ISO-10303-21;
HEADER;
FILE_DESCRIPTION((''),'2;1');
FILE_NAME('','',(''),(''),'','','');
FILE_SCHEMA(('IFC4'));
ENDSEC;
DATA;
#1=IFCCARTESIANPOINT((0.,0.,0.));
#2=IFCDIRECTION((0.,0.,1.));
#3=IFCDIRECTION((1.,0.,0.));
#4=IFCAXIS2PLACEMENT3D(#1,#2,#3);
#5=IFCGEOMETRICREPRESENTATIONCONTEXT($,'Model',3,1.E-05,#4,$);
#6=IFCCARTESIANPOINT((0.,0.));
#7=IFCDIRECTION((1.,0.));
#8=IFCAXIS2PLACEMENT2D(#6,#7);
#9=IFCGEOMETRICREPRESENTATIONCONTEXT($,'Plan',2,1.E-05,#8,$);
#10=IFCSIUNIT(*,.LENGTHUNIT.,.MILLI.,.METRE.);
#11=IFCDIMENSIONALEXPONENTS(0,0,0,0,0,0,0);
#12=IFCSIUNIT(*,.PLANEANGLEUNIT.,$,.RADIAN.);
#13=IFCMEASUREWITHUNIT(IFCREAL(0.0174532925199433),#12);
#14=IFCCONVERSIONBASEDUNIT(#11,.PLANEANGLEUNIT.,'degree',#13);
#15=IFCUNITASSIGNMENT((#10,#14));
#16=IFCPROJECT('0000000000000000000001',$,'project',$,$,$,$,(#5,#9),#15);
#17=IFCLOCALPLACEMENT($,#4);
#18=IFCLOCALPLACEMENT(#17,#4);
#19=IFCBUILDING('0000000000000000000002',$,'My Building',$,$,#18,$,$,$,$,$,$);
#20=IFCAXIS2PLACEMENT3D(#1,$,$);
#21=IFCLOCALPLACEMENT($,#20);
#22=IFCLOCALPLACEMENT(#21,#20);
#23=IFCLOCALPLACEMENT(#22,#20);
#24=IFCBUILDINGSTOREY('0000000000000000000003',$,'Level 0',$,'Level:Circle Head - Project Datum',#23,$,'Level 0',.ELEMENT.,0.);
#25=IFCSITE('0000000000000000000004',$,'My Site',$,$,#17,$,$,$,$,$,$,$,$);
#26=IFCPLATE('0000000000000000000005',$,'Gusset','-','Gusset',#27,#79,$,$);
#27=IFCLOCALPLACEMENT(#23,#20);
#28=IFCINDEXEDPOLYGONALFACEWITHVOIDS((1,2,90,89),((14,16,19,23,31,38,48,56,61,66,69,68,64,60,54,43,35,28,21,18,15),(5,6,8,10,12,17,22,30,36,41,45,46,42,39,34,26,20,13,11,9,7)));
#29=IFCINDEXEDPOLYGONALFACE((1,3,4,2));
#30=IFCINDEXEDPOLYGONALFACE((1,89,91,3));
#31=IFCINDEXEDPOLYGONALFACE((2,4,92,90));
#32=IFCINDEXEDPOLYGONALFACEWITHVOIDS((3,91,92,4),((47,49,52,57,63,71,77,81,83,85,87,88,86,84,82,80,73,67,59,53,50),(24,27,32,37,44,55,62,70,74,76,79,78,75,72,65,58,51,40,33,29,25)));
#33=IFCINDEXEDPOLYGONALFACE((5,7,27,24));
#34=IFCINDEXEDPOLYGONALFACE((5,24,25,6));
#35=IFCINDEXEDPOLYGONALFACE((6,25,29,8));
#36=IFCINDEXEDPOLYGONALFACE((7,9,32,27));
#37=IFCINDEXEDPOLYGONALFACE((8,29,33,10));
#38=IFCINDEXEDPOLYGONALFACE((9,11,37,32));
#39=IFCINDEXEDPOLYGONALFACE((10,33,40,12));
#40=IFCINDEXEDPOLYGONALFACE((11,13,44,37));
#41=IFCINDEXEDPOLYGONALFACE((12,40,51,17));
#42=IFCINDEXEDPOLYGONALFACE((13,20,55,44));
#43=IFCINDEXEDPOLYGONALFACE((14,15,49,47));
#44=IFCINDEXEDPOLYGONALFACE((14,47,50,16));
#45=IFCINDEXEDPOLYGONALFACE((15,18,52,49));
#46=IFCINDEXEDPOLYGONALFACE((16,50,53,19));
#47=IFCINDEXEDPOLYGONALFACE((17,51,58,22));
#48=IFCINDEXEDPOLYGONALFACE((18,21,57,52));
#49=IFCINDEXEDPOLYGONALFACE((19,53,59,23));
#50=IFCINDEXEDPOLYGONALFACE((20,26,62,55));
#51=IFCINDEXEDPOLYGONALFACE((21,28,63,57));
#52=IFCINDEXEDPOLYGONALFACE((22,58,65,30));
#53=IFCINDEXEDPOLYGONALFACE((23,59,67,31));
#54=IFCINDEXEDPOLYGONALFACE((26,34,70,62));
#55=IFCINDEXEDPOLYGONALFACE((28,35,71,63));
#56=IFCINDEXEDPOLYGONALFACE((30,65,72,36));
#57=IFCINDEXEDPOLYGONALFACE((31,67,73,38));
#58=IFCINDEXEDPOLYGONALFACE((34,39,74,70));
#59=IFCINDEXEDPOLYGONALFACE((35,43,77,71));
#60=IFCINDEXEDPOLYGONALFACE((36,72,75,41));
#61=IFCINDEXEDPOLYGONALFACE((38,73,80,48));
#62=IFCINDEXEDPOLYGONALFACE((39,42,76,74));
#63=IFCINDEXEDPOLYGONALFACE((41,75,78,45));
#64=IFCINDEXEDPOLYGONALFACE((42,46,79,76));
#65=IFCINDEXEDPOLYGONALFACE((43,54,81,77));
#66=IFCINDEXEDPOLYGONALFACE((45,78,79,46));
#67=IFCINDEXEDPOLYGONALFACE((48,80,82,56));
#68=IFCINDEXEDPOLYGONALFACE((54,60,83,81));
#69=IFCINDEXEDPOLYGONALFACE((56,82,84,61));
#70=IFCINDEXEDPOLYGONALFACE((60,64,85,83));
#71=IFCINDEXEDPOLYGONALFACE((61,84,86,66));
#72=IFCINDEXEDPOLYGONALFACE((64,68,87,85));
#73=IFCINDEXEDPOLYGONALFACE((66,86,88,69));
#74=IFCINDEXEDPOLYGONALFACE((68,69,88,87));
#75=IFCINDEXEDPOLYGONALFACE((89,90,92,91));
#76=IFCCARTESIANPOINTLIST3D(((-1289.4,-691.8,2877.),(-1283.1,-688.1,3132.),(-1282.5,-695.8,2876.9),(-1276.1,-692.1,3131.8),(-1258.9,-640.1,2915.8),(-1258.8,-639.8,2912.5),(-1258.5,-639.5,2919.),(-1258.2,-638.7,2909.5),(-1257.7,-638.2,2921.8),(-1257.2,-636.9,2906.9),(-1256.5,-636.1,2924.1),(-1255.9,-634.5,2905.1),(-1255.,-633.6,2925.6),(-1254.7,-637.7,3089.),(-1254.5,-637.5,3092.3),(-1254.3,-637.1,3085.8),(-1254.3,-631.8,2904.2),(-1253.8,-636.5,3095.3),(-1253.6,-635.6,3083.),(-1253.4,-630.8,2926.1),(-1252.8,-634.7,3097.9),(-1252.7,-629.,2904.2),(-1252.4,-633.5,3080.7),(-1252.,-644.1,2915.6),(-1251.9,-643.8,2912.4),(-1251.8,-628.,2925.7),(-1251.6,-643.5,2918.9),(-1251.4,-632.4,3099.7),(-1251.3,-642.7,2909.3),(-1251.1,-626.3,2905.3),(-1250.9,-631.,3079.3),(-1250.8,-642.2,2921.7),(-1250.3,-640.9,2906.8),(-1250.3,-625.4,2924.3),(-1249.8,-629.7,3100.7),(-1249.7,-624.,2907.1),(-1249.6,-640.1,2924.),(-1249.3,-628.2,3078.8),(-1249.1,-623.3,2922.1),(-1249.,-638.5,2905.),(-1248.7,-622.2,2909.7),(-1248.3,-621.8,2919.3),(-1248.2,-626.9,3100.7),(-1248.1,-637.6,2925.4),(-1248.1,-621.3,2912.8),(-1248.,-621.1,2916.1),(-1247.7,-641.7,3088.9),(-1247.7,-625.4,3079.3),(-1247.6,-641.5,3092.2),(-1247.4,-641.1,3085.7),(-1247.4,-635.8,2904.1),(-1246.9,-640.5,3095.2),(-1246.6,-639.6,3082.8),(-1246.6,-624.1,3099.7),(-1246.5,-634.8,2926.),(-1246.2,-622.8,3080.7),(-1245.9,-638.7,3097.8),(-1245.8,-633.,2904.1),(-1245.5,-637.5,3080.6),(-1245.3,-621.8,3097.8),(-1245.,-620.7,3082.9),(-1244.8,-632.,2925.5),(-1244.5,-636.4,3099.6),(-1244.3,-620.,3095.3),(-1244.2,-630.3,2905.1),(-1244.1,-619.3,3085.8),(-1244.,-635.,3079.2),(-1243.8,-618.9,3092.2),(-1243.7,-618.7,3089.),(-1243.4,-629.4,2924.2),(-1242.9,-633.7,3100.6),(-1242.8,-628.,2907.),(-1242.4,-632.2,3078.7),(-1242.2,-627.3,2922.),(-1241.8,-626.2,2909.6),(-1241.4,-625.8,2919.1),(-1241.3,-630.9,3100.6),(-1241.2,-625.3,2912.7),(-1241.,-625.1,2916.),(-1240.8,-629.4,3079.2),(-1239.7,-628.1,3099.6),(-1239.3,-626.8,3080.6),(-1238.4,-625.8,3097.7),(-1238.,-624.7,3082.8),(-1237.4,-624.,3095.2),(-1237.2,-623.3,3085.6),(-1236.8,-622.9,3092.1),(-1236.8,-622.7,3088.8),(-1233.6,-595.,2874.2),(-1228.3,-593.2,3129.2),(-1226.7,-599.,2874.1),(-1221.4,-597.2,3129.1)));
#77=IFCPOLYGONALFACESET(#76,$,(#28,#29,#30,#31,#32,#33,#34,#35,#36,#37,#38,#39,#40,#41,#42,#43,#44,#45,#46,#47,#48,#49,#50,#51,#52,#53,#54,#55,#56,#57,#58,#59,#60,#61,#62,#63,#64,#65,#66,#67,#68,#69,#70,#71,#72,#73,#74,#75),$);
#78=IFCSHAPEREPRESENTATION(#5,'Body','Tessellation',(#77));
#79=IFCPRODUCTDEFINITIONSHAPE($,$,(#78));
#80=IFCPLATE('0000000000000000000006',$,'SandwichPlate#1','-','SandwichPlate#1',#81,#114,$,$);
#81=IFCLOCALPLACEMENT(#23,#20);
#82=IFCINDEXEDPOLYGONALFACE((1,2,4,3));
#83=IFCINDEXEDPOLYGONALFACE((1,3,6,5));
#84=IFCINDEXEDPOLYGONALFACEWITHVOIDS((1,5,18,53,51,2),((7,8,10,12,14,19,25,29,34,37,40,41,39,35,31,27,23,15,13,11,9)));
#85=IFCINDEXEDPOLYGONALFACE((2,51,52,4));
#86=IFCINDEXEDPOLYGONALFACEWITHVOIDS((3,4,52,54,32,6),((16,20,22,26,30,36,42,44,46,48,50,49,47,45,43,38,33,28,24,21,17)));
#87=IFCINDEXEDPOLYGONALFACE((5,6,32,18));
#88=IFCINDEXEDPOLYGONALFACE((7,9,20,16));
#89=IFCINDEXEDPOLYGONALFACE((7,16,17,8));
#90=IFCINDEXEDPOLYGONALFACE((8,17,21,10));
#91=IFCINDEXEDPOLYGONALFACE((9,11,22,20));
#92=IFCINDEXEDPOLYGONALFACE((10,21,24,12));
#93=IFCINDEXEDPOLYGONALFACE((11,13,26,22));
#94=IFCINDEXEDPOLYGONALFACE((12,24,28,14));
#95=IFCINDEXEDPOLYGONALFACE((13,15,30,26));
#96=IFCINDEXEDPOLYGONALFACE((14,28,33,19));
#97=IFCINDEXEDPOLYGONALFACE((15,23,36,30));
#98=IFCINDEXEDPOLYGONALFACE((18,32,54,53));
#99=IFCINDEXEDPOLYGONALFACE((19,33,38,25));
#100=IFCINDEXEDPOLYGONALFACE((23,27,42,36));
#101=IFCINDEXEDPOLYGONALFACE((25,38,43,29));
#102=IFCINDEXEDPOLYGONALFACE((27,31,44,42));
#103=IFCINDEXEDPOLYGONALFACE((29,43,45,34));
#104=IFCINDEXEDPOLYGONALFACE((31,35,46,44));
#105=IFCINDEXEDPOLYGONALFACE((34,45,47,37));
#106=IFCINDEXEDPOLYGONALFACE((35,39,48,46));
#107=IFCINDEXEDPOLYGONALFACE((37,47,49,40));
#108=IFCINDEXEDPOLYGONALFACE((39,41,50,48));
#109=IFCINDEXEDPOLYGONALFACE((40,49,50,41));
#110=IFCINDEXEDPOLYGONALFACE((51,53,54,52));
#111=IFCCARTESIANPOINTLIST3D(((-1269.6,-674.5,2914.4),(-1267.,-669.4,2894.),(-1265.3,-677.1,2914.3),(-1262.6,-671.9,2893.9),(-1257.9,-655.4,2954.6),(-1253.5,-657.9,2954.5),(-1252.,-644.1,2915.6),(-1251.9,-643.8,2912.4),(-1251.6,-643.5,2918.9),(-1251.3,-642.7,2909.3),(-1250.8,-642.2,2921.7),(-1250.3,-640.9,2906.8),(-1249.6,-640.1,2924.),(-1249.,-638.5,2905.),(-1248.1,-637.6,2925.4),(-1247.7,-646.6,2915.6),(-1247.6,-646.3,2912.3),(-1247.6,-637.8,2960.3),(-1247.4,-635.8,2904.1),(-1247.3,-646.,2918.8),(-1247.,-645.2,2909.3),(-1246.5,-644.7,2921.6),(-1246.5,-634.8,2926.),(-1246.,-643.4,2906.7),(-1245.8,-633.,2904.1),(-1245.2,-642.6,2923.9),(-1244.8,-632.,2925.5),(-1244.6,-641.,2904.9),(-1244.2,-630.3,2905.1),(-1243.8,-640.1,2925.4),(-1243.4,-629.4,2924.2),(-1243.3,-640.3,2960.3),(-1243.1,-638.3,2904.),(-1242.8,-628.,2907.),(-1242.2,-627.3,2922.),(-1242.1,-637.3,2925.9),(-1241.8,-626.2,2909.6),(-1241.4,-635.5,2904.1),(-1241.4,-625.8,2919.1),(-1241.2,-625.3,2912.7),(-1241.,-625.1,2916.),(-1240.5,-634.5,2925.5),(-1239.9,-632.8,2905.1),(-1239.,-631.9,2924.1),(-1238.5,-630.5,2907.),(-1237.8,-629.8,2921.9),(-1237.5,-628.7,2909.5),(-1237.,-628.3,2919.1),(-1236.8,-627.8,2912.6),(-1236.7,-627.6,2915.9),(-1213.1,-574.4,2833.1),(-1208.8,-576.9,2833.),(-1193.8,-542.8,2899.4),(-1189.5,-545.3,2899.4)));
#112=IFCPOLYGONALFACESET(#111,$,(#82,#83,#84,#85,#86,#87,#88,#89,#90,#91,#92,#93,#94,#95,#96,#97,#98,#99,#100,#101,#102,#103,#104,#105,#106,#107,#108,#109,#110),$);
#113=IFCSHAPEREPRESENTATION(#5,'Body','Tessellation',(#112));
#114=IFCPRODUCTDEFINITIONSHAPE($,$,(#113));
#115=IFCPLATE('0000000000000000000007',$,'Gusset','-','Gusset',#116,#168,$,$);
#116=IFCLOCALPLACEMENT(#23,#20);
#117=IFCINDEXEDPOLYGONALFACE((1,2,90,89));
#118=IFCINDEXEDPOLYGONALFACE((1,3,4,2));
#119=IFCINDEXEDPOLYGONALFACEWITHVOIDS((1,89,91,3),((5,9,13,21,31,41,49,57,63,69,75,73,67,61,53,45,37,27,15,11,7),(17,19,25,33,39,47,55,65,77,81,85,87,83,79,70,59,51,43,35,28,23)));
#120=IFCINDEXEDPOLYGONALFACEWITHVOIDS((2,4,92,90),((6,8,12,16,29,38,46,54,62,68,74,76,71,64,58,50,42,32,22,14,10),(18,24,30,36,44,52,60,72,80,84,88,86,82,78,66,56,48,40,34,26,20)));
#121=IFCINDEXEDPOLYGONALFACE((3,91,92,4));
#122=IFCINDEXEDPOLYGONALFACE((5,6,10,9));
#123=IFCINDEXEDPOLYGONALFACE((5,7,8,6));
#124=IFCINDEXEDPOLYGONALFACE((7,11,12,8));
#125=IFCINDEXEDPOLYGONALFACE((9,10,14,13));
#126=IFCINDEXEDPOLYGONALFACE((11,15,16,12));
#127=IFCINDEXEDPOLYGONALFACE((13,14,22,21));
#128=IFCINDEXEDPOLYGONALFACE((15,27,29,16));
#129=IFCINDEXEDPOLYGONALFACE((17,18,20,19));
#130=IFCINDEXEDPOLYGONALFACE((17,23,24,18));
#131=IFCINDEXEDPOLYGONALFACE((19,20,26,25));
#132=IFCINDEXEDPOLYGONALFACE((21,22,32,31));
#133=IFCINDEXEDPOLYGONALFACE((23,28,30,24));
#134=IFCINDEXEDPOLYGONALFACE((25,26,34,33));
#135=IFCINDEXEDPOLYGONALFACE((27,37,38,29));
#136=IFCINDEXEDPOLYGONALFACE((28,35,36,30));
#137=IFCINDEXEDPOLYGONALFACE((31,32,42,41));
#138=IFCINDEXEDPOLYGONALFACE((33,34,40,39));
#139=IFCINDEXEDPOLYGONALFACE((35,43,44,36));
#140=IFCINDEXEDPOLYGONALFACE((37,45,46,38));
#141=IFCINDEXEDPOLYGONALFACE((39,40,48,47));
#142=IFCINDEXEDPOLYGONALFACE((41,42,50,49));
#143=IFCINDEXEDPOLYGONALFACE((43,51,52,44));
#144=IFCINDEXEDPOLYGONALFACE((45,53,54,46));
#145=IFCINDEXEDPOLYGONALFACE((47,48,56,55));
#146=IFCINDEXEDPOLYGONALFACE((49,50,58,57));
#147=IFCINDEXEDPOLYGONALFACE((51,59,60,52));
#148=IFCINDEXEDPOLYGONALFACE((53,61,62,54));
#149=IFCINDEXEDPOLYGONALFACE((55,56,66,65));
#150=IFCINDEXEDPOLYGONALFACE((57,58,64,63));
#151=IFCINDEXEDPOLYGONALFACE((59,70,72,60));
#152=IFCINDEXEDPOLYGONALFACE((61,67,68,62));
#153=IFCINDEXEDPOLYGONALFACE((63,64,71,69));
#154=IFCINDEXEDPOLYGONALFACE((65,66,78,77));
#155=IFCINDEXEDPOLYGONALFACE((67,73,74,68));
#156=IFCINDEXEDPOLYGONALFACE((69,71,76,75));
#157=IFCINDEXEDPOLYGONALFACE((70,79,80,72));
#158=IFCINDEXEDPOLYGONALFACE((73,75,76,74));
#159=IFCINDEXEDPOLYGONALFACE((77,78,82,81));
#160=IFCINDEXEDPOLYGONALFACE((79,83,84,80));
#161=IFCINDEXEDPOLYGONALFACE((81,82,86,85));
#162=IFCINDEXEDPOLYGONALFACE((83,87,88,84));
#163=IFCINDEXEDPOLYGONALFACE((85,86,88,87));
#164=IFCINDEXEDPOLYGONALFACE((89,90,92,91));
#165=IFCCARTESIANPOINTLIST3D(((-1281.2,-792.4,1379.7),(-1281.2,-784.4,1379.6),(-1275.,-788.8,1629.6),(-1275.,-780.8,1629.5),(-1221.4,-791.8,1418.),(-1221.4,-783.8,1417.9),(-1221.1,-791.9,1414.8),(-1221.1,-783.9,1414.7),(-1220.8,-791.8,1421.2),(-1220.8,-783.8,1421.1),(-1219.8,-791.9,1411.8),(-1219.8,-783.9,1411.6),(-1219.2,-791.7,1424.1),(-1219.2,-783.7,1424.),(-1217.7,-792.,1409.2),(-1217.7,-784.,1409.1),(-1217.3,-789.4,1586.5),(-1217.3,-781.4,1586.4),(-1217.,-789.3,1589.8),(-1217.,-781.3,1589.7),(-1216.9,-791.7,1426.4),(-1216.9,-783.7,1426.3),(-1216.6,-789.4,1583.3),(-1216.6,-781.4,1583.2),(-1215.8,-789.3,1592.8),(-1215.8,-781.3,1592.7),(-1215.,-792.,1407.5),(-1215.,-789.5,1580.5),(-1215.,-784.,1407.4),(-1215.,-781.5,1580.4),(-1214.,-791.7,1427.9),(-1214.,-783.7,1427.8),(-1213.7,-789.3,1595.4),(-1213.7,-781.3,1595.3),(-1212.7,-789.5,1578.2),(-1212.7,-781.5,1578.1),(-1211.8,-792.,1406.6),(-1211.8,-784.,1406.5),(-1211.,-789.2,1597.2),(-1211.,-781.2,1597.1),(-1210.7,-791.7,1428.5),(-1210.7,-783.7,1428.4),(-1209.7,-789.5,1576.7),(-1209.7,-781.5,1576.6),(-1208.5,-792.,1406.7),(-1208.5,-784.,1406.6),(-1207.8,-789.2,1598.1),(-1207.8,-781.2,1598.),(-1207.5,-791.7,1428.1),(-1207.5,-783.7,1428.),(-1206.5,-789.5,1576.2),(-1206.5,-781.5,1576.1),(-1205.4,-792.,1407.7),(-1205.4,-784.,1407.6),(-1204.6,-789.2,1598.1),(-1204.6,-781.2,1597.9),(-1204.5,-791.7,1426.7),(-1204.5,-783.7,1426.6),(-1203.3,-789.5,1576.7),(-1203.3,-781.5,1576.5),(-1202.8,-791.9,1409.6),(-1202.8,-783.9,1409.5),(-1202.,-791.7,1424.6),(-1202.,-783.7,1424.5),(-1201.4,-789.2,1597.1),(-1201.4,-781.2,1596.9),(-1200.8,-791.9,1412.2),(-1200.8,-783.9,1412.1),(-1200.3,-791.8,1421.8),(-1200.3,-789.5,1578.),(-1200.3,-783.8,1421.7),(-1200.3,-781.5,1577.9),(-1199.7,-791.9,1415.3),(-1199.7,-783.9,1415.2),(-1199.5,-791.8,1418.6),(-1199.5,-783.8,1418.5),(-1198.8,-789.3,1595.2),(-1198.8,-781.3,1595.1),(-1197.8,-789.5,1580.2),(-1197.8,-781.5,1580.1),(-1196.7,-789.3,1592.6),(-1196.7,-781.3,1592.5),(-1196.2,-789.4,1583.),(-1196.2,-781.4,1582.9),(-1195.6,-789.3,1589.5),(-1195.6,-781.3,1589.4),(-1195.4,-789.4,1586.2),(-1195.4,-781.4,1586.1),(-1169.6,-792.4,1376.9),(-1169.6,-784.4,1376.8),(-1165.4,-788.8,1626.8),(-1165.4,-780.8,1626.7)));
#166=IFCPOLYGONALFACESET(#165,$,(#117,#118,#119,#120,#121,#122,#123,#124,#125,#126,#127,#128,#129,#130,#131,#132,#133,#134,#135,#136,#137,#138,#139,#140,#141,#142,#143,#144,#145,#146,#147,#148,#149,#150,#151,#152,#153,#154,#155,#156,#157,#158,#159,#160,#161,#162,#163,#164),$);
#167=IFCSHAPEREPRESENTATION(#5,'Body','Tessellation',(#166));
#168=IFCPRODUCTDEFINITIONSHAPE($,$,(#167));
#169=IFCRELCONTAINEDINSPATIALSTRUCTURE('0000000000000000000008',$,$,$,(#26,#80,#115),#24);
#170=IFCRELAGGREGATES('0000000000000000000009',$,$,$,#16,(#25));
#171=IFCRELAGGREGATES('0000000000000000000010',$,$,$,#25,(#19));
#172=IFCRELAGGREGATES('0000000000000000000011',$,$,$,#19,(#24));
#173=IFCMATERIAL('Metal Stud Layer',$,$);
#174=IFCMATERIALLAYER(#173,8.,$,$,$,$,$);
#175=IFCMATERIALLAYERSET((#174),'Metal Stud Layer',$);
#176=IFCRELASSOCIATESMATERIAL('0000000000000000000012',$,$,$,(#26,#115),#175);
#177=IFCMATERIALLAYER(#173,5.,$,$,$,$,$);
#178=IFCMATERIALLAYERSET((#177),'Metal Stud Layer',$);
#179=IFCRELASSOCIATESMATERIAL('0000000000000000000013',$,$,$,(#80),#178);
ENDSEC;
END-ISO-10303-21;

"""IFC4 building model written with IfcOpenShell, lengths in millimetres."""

from ifc_helpers import new_model, entity, si_unit, converted_unit, frame, origin, origin_with_axes, origin_2d_with_axis, place, context, project, spatial, polyline, circle, outline, extrude, material, layer, layer_set, element, save


model = new_model("IFC4")

# Units and contexts
model_context = context("Model", 3, precision=1e-05, world=origin_with_axes())
plan_context = context("Plan", 2, precision=1e-05, world=origin_2d_with_axis())
ifc_project = project(units=[si_unit("LENGTHUNIT", "METRE", prefix="MILLI"), converted_unit("PLANEANGLEUNIT", "degree", entity("IfcReal", 0.0174532925199433), si_unit("PLANEANGLEUNIT", "RADIAN"), dimensions=[0, 0, 0, 0, 0, 0, 0])], contexts=[model_context, plan_context])

# Site, building, storey
site_placement = place(None, origin_with_axes())
site = spatial("IfcSite", under=ifc_project, at=site_placement, Name="My Site")
building_placement = place(site_placement, origin_with_axes())
building = spatial("IfcBuilding", under=site, at=building_placement, Name="My Building")
placement_1 = place(None, origin())
placement_2 = place(placement_1, origin())
storey_placement = place(placement_2, origin())
storey = spatial("IfcBuildingStorey", under=building, at=storey_placement, Name="Level 0", ObjectType="Level:Circle Head - Project Datum", LongName="Level 0", CompositionType="ELEMENT", Elevation=0.0)

# Plates, openings
ifc_material_1 = material(Name="Metal Stud Layer")
ifc_layer_1 = layer(ifc_material_1, 8.0)
ifc_layer_set_1 = layer_set([ifc_layer_1], Name="Metal Stud Layer")
plate_1_placement = place(storey_placement, frame((-1281.9, -686.2, 3131.9), z_axis=(0.865935, -0.499948, -0.014432), x_axis=(-0.02499, -0.014428, -0.999584)))
plate_1 = element("IfcPlate", 1, at=plate_1_placement, inside=storey, material=ifc_layer_set_1, Name="Gusset", Description="-", ObjectType="Gusset", context=model_context, shape_type="SweptSolid", body=[
    extrude(outline(polyline([(0.0, -2.3), (255.1, -2.3), (255.1, 109.5), (0.0, 107.4), (0.0, -2.3)])), origin_with_axes(), (0.0, 0.0, 1.0), 8.0),
])
opening_1_placement = place(plate_1_placement, frame((40.4, 67.6, 8.5), z_axis=(0.0, 0.0, -1.0), x_axis=(-0.519472, 0.854487, 0.0)))
element("IfcOpeningElement", 2, at=opening_1_placement, cuts=plate_1, ObjectType="Opening", context=model_context, shape_type="SweptSolid", body=[
    extrude(circle(Radius=11.0, at=origin_2d_with_axis()), origin(), (0.0, 0.0, 1.0), 9.0),
])
opening_2_placement = place(plate_1_placement, frame((215.2, 67.8, 8.5), z_axis=(0.0, 0.0, -1.0), x_axis=(0.465435, 0.885082, 0.0)))
element("IfcOpeningElement", 3, at=opening_2_placement, cuts=plate_1, ObjectType="Opening", context=model_context, shape_type="SweptSolid", body=[
    extrude(circle(Radius=11.0, at=origin_2d_with_axis()), origin(), (0.0, 0.0, 1.0), 9.0),
])
ifc_layer_2 = layer(ifc_material_1, 5.0)
ifc_layer_set_2 = layer_set([ifc_layer_2], Name="Metal Stud Layer")
plate_2_placement = place(storey_placement, frame((-1269.1, -683.3, 2901.2), z_axis=(-0.865935, 0.499948, 0.014432), x_axis=(0.254617, 0.415806, 0.873084)))
plate_2 = element("IfcPlate", 4, at=plate_2_placement, inside=storey, material=ifc_layer_set_2, Name="SandwichPlate#1", Description="-", ObjectType="SandwichPlate#1", context=model_context, shape_type="SweptSolid", body=[
    extrude(outline(polyline([(0.0, 0.0), (76.0, 0.0), (76.0, 140.0), (0.0, 140.0), (0.0, 0.0)])), origin_with_axes(), (0.0, 0.0, 1.0), 5.0),
])
opening_3_placement = place(plate_2_placement, frame((38.0, 40.0, -0.5), z_axis=(0.0, 0.0, 1.0), x_axis=(0.0, 1.0, 0.0)))
element("IfcOpeningElement", 5, at=opening_3_placement, cuts=plate_2, ObjectType="Opening", context=model_context, shape_type="SweptSolid", body=[
    extrude(circle(Radius=11.0, at=origin_2d_with_axis()), origin(), (0.0, 0.0, 1.0), 6.0),
])
opening_4_placement = place(plate_2_placement, frame((0.0, 0.0, 0.0), z_axis=(0.0, 0.0, 1.0), x_axis=(1.0, 0.0, 0.0)))
element("IfcOpeningElement", 6, at=opening_4_placement, cuts=plate_2, ObjectType="Opening", context=model_context, shape_type="SweptSolid", body=[
    extrude(outline(polyline([(0.0, 0.0), (15.0, 0.0), (0.0, 15.0), (0.0, 0.0)])), origin(), (0.0, 0.0, 1.0), 5.0),
])
opening_5_placement = place(plate_2_placement, frame((0.0, 0.0, 0.0), z_axis=(0.0, 0.0, 1.0), x_axis=(1.0, 0.0, 0.0)))
element("IfcOpeningElement", 7, at=opening_5_placement, cuts=plate_2, ObjectType="Opening", context=model_context, shape_type="SweptSolid", body=[
    extrude(outline(polyline([(76.0, 0.0), (76.0, 15.0), (61.0, 0.0), (76.0, 0.0)])), origin(), (0.0, 0.0, 1.0), 5.0),
])
plate_3_placement = place(storey_placement, frame((-1272.8, -780.8, 1628.9), z_axis=(0.0, -0.999896, 0.014432), x_axis=(-0.02499, -0.014428, -0.999584)))
plate_3 = element("IfcPlate", 8, at=plate_3_placement, inside=storey, material=ifc_layer_set_1, Name="Gusset", Description="-", ObjectType="Gusset", context=model_context, shape_type="SweptSolid", body=[
    extrude(outline(polyline([(-0.5, -2.2), (249.5, -2.2), (249.5, 109.5), (-0.5, 107.4), (-0.5, -2.2)])), origin_with_axes(), (0.0, 0.0, 1.0), 8.0),
])
opening_6_placement = place(plate_3_placement, frame((40.2, 67.5, 8.5), z_axis=(0.0, 0.0, -1.0), x_axis=(-0.509073, 0.860723, 0.0)))
element("IfcOpeningElement", 9, at=opening_6_placement, cuts=plate_3, ObjectType="Opening", context=model_context, shape_type="SweptSolid", body=[
    extrude(circle(Radius=11.0, at=origin_2d_with_axis()), origin(), (0.0, 0.0, 1.0), 9.0),
])
opening_7_placement = place(plate_3_placement, frame((209.9, 67.6, 8.5), z_axis=(0.0, 0.0, -1.0), x_axis=(0.455108, 0.890436, 0.0)))
element("IfcOpeningElement", 10, at=opening_7_placement, cuts=plate_3, ObjectType="Opening", context=model_context, shape_type="SweptSolid", body=[
    extrude(circle(Radius=11.0, at=origin_2d_with_axis()), origin(), (0.0, 0.0, 1.0), 9.0),
])

save(model, "model.ifc")
